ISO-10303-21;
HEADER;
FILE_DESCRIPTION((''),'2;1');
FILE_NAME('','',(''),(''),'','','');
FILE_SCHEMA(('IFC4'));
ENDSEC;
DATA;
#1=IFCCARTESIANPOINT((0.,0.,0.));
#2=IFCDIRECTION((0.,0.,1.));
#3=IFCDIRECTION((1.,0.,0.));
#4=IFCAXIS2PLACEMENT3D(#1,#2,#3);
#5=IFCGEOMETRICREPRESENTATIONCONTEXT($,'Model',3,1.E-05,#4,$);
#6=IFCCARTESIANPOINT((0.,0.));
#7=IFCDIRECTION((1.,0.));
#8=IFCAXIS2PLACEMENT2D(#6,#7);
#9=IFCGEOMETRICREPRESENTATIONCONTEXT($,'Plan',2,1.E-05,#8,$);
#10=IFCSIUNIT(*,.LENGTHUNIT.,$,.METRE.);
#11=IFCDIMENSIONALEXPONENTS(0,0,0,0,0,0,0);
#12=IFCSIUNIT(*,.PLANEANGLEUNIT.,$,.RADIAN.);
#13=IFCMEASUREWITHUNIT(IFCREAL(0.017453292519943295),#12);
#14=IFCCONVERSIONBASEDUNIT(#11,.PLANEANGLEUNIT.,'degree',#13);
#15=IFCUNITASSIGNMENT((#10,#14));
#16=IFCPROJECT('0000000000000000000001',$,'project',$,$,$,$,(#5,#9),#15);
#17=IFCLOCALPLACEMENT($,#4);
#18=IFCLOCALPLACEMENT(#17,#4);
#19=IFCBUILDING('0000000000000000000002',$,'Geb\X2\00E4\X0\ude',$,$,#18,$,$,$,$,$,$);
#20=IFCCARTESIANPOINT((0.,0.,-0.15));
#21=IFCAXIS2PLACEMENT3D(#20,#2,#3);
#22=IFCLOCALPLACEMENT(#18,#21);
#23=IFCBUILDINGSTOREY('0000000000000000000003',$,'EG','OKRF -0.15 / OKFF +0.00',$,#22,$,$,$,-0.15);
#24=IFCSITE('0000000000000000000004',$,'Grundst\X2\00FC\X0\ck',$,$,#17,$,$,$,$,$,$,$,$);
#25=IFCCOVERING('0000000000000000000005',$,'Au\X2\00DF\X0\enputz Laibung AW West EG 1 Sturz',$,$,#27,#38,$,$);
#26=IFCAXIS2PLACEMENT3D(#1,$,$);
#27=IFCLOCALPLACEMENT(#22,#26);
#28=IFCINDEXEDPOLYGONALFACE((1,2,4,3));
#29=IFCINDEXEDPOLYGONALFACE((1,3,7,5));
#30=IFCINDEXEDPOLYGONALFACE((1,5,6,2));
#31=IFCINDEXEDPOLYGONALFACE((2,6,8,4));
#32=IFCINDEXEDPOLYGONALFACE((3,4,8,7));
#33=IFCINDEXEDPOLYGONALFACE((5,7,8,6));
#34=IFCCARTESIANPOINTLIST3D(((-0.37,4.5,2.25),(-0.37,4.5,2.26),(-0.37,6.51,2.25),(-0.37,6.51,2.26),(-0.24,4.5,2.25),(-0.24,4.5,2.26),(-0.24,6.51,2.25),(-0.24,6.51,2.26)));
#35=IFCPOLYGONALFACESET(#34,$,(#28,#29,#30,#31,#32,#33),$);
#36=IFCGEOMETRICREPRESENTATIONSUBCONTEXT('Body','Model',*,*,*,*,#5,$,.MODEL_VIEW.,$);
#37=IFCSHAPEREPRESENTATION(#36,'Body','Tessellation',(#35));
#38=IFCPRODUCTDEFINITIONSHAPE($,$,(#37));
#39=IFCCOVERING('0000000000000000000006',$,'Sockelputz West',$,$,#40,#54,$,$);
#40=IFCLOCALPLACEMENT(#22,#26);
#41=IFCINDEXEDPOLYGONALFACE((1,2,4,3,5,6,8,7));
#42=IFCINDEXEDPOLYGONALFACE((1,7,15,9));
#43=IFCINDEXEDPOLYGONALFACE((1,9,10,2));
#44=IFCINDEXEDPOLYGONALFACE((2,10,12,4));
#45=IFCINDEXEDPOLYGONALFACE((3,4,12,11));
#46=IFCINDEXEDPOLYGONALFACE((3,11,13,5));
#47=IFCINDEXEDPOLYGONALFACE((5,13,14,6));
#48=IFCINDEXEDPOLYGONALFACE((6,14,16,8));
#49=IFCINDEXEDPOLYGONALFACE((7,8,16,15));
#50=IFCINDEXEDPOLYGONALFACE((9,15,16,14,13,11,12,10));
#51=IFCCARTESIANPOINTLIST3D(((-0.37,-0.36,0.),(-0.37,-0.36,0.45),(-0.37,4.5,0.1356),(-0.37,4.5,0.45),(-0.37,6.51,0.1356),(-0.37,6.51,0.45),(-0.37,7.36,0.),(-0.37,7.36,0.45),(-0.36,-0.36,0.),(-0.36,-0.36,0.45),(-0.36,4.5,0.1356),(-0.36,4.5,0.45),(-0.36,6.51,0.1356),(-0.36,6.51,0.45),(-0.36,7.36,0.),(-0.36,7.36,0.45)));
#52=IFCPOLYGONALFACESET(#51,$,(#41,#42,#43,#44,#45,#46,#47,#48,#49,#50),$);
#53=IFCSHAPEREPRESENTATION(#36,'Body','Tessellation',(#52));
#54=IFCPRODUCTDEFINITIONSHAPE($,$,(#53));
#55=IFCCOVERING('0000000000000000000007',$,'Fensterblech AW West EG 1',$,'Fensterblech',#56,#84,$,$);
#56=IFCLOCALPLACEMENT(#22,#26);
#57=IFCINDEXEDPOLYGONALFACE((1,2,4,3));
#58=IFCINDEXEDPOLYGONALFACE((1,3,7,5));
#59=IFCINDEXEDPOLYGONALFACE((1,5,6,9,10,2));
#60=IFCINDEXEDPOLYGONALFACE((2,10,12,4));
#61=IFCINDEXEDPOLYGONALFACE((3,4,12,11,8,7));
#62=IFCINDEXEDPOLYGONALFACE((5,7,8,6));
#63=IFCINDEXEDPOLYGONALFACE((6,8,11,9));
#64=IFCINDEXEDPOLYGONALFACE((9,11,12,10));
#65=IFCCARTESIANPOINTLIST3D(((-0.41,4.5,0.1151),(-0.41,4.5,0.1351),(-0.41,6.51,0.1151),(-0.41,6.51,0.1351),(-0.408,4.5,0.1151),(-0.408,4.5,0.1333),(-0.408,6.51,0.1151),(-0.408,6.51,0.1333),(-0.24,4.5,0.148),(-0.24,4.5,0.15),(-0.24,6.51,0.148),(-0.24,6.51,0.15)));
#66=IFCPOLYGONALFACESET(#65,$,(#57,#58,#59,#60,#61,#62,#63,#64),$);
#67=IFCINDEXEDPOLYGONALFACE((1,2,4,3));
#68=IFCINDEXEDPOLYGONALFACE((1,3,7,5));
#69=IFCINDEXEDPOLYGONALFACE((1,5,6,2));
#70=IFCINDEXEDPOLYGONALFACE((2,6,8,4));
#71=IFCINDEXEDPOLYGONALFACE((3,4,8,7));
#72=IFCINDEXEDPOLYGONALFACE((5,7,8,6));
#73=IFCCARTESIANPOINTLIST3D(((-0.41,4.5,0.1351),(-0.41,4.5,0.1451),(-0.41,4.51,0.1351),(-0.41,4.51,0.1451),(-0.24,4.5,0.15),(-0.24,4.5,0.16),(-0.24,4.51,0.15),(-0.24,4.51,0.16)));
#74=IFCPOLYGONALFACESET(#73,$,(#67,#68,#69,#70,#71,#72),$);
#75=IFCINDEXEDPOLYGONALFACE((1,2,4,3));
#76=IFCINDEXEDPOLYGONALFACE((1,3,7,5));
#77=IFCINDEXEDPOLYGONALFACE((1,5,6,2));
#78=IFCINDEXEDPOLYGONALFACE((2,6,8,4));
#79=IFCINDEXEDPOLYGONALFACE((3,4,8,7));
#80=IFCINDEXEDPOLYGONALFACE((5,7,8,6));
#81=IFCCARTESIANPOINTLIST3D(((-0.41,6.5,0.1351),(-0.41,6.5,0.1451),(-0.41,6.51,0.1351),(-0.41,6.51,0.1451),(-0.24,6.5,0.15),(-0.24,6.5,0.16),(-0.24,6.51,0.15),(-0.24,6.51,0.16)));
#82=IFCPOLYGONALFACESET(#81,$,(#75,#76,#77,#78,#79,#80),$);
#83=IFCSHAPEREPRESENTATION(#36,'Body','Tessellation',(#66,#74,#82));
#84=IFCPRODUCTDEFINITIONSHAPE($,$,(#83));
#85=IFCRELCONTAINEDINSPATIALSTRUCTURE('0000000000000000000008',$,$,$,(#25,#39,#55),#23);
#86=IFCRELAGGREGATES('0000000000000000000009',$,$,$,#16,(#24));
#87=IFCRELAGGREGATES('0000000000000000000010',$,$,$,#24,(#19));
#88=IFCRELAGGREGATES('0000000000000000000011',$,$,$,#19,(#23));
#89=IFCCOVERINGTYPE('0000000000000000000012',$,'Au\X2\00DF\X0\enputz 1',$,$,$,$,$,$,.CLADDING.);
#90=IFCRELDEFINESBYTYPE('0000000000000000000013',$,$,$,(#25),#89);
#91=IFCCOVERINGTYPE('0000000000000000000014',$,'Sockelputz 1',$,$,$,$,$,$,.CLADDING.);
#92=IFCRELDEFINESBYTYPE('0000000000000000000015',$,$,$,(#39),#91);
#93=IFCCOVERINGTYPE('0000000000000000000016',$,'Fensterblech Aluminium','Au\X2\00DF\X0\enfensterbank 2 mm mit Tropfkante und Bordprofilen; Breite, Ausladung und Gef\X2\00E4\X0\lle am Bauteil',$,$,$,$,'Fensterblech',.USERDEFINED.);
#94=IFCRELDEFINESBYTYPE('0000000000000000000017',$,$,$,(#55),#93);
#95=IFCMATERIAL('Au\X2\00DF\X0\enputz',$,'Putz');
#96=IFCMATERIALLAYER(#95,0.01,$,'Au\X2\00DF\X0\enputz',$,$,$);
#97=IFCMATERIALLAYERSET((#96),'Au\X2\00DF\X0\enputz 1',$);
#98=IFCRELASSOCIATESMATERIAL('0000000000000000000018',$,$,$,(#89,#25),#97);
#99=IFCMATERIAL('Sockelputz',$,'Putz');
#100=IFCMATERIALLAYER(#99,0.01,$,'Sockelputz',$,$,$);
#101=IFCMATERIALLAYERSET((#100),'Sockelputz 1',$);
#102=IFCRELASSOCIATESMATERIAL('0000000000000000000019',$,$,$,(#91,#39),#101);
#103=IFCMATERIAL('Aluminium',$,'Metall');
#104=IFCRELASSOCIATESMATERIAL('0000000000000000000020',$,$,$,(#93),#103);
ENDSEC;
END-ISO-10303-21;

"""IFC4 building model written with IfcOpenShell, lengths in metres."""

from ifc_helpers import new_model, entity, si_unit, converted_unit, frame, origin_with_axes, origin_2d_with_axis, place, context, subcontext, project, spatial, polyline, indexed_curve, outline, extrude, material, layer, layer_set, layer_usage, type_object, element, save


model = new_model("IFC4")

# Units and contexts
model_context = context("Model", 3, precision=1e-05, world=origin_with_axes())
plan_context = context("Plan", 2, precision=1e-05, world=origin_2d_with_axis())
body_context_1 = subcontext(model_context, "Body", "Model", "MODEL_VIEW")
ifc_project = project(units=[si_unit("LENGTHUNIT", "METRE"), converted_unit("PLANEANGLEUNIT", "degree", entity("IfcReal", 0.017453292519943295), si_unit("PLANEANGLEUNIT", "RADIAN"), dimensions=[0, 0, 0, 0, 0, 0, 0])], contexts=[model_context, plan_context])

# Site, building, storey
site_placement = place(None, origin_with_axes())
site = spatial("IfcSite", under=ifc_project, at=site_placement, Name="Grundstück")
building_placement = place(site_placement, origin_with_axes())
building = spatial("IfcBuilding", under=site, at=building_placement, Name="Gebäude")
storey_placement = place(building_placement, frame((0.0, 0.0, -0.15), z_axis=(0.0, 0.0, 1.0), x_axis=(1.0, 0.0, 0.0)))
storey = spatial("IfcBuildingStorey", under=building, at=storey_placement, Name="EG", Description="OKRF -0.15 / OKFF +0.00", Elevation=-0.15)

# Covering
ifc_material_1 = material(Name="Außenputz", Category="Putz")
ifc_layer_1 = layer(ifc_material_1, 0.01, Name="Außenputz")
ifc_layer_set_1 = layer_set([ifc_layer_1], Name="Außenputz 1")
ifc_layer_usage_1 = layer_usage(ifc_layer_set_1, "AXIS3", "POSITIVE", 2.25)
covering_type_1 = type_object("IfcCoveringType", Name="Außenputz 1", PredefinedType="CLADDING", material=ifc_layer_set_1)
covering_1_placement = place(storey_placement, frame((0.0, 0.0, 0.0), z_axis=(0.0, 0.0, 1.0), x_axis=(0.0, 1.0, 0.0)))
element("IfcCovering", 1, at=covering_1_placement, inside=storey, type_object=covering_type_1, material=ifc_layer_usage_1, Name="Außenputz Laibung AW West EG 1 Sturz", context=body_context_1, shape_type="SweptSolid", body=[
    extrude(outline(polyline([(0.24, 2.25), (0.37, 2.25), (0.37, 2.26), (0.24, 2.26), (0.24, 2.25)])), frame((4.5, 0.0, 0.0), z_axis=(1.0, 0.0, 0.0), x_axis=(0.0, 1.0, 0.0)), (0.0, 0.0, 1.0), 2.01),
])

# Covering, opening
ifc_material_2 = material(Name="Sockelputz", Category="Putz")
ifc_layer_2 = layer(ifc_material_2, 0.01, Name="Sockelputz")
ifc_layer_set_2 = layer_set([ifc_layer_2], Name="Sockelputz 1")
ifc_layer_usage_2 = layer_usage(ifc_layer_set_2, "AXIS2", "POSITIVE", 0.0)
covering_type_2 = type_object("IfcCoveringType", Name="Sockelputz 1", PredefinedType="CLADDING", material=ifc_layer_set_2)
covering_2_placement = place(storey_placement, frame((-0.36, -0.36, 0.0), z_axis=(0.0, 0.0, 1.0), x_axis=(0.0, 1.0, 0.0)))
covering_2 = element("IfcCovering", 2, at=covering_2_placement, inside=storey, type_object=covering_type_2, material=ifc_layer_usage_2, Name="Sockelputz West", context=body_context_1, shape_type="SweptSolid", body=[
    extrude(outline(indexed_curve([(0.0, 0.0), (0.0, 0.01), (7.72, 0.01), (7.72, 0.0), (0.0, 0.0)], self_intersect=False)), origin_with_axes(), (0.0, 0.0, 1.0), 0.45),
])
opening_1_placement = place(covering_2_placement, frame((4.86, -0.05, 0.1356), z_axis=(0.0, 0.0, 1.0), x_axis=(1.0, 0.0, 0.0)))
element("IfcOpeningElement", 3, at=opening_1_placement, cuts=covering_2, context=body_context_1, shape_type="SweptSolid", body=[
    extrude(outline(indexed_curve([(0.0, 0.0), (0.0, 0.11), (2.01, 0.11), (2.01, 0.0), (0.0, 0.0)], self_intersect=False)), origin_with_axes(), (0.0, 0.0, 1.0), 0.3144),
])

# Covering
ifc_material_3 = material(Name="Aluminium", Category="Metall")
covering_type_3 = type_object("IfcCoveringType", Name="Fensterblech Aluminium", Description="Außenfensterbank 2 mm mit Tropfkante und Bordprofilen; Breite, Ausladung und Gefälle am Bauteil", ElementType="Fensterblech", PredefinedType="USERDEFINED", material=ifc_material_3)
covering_3_placement = place(storey_placement, frame((0.0, 0.0, 0.0), z_axis=(0.0, 0.0, 1.0), x_axis=(0.0, 1.0, 0.0)))
element("IfcCovering", 4, at=covering_3_placement, inside=storey, type_object=covering_type_3, Name="Fensterblech AW West EG 1", ObjectType="Fensterblech", context=body_context_1, shape_type="SweptSolid", body=[
    extrude(outline(polyline([(0.24, 0.148), (0.408, 0.1333), (0.408, 0.1151), (0.41, 0.1151), (0.41, 0.1351), (0.24, 0.15), (0.24, 0.148)])), frame((4.5, 0.0, 0.0), z_axis=(1.0, 0.0, 0.0), x_axis=(0.0, 1.0, 0.0)), (0.0, 0.0, 1.0), 2.01),
    extrude(outline(polyline([(0.24, 0.15), (0.41, 0.1351), (0.41, 0.1451), (0.24, 0.16), (0.24, 0.15)])), frame((4.5, 0.0, 0.0), z_axis=(1.0, 0.0, 0.0), x_axis=(0.0, 1.0, 0.0)), (0.0, 0.0, 1.0), 0.01),
    extrude(outline(polyline([(0.24, 0.15), (0.41, 0.1351), (0.41, 0.1451), (0.24, 0.16), (0.24, 0.15)])), frame((6.5, 0.0, 0.0), z_axis=(1.0, 0.0, 0.0), x_axis=(0.0, 1.0, 0.0)), (0.0, 0.0, 1.0), 0.01),
])

save(model, "model.ifc")
